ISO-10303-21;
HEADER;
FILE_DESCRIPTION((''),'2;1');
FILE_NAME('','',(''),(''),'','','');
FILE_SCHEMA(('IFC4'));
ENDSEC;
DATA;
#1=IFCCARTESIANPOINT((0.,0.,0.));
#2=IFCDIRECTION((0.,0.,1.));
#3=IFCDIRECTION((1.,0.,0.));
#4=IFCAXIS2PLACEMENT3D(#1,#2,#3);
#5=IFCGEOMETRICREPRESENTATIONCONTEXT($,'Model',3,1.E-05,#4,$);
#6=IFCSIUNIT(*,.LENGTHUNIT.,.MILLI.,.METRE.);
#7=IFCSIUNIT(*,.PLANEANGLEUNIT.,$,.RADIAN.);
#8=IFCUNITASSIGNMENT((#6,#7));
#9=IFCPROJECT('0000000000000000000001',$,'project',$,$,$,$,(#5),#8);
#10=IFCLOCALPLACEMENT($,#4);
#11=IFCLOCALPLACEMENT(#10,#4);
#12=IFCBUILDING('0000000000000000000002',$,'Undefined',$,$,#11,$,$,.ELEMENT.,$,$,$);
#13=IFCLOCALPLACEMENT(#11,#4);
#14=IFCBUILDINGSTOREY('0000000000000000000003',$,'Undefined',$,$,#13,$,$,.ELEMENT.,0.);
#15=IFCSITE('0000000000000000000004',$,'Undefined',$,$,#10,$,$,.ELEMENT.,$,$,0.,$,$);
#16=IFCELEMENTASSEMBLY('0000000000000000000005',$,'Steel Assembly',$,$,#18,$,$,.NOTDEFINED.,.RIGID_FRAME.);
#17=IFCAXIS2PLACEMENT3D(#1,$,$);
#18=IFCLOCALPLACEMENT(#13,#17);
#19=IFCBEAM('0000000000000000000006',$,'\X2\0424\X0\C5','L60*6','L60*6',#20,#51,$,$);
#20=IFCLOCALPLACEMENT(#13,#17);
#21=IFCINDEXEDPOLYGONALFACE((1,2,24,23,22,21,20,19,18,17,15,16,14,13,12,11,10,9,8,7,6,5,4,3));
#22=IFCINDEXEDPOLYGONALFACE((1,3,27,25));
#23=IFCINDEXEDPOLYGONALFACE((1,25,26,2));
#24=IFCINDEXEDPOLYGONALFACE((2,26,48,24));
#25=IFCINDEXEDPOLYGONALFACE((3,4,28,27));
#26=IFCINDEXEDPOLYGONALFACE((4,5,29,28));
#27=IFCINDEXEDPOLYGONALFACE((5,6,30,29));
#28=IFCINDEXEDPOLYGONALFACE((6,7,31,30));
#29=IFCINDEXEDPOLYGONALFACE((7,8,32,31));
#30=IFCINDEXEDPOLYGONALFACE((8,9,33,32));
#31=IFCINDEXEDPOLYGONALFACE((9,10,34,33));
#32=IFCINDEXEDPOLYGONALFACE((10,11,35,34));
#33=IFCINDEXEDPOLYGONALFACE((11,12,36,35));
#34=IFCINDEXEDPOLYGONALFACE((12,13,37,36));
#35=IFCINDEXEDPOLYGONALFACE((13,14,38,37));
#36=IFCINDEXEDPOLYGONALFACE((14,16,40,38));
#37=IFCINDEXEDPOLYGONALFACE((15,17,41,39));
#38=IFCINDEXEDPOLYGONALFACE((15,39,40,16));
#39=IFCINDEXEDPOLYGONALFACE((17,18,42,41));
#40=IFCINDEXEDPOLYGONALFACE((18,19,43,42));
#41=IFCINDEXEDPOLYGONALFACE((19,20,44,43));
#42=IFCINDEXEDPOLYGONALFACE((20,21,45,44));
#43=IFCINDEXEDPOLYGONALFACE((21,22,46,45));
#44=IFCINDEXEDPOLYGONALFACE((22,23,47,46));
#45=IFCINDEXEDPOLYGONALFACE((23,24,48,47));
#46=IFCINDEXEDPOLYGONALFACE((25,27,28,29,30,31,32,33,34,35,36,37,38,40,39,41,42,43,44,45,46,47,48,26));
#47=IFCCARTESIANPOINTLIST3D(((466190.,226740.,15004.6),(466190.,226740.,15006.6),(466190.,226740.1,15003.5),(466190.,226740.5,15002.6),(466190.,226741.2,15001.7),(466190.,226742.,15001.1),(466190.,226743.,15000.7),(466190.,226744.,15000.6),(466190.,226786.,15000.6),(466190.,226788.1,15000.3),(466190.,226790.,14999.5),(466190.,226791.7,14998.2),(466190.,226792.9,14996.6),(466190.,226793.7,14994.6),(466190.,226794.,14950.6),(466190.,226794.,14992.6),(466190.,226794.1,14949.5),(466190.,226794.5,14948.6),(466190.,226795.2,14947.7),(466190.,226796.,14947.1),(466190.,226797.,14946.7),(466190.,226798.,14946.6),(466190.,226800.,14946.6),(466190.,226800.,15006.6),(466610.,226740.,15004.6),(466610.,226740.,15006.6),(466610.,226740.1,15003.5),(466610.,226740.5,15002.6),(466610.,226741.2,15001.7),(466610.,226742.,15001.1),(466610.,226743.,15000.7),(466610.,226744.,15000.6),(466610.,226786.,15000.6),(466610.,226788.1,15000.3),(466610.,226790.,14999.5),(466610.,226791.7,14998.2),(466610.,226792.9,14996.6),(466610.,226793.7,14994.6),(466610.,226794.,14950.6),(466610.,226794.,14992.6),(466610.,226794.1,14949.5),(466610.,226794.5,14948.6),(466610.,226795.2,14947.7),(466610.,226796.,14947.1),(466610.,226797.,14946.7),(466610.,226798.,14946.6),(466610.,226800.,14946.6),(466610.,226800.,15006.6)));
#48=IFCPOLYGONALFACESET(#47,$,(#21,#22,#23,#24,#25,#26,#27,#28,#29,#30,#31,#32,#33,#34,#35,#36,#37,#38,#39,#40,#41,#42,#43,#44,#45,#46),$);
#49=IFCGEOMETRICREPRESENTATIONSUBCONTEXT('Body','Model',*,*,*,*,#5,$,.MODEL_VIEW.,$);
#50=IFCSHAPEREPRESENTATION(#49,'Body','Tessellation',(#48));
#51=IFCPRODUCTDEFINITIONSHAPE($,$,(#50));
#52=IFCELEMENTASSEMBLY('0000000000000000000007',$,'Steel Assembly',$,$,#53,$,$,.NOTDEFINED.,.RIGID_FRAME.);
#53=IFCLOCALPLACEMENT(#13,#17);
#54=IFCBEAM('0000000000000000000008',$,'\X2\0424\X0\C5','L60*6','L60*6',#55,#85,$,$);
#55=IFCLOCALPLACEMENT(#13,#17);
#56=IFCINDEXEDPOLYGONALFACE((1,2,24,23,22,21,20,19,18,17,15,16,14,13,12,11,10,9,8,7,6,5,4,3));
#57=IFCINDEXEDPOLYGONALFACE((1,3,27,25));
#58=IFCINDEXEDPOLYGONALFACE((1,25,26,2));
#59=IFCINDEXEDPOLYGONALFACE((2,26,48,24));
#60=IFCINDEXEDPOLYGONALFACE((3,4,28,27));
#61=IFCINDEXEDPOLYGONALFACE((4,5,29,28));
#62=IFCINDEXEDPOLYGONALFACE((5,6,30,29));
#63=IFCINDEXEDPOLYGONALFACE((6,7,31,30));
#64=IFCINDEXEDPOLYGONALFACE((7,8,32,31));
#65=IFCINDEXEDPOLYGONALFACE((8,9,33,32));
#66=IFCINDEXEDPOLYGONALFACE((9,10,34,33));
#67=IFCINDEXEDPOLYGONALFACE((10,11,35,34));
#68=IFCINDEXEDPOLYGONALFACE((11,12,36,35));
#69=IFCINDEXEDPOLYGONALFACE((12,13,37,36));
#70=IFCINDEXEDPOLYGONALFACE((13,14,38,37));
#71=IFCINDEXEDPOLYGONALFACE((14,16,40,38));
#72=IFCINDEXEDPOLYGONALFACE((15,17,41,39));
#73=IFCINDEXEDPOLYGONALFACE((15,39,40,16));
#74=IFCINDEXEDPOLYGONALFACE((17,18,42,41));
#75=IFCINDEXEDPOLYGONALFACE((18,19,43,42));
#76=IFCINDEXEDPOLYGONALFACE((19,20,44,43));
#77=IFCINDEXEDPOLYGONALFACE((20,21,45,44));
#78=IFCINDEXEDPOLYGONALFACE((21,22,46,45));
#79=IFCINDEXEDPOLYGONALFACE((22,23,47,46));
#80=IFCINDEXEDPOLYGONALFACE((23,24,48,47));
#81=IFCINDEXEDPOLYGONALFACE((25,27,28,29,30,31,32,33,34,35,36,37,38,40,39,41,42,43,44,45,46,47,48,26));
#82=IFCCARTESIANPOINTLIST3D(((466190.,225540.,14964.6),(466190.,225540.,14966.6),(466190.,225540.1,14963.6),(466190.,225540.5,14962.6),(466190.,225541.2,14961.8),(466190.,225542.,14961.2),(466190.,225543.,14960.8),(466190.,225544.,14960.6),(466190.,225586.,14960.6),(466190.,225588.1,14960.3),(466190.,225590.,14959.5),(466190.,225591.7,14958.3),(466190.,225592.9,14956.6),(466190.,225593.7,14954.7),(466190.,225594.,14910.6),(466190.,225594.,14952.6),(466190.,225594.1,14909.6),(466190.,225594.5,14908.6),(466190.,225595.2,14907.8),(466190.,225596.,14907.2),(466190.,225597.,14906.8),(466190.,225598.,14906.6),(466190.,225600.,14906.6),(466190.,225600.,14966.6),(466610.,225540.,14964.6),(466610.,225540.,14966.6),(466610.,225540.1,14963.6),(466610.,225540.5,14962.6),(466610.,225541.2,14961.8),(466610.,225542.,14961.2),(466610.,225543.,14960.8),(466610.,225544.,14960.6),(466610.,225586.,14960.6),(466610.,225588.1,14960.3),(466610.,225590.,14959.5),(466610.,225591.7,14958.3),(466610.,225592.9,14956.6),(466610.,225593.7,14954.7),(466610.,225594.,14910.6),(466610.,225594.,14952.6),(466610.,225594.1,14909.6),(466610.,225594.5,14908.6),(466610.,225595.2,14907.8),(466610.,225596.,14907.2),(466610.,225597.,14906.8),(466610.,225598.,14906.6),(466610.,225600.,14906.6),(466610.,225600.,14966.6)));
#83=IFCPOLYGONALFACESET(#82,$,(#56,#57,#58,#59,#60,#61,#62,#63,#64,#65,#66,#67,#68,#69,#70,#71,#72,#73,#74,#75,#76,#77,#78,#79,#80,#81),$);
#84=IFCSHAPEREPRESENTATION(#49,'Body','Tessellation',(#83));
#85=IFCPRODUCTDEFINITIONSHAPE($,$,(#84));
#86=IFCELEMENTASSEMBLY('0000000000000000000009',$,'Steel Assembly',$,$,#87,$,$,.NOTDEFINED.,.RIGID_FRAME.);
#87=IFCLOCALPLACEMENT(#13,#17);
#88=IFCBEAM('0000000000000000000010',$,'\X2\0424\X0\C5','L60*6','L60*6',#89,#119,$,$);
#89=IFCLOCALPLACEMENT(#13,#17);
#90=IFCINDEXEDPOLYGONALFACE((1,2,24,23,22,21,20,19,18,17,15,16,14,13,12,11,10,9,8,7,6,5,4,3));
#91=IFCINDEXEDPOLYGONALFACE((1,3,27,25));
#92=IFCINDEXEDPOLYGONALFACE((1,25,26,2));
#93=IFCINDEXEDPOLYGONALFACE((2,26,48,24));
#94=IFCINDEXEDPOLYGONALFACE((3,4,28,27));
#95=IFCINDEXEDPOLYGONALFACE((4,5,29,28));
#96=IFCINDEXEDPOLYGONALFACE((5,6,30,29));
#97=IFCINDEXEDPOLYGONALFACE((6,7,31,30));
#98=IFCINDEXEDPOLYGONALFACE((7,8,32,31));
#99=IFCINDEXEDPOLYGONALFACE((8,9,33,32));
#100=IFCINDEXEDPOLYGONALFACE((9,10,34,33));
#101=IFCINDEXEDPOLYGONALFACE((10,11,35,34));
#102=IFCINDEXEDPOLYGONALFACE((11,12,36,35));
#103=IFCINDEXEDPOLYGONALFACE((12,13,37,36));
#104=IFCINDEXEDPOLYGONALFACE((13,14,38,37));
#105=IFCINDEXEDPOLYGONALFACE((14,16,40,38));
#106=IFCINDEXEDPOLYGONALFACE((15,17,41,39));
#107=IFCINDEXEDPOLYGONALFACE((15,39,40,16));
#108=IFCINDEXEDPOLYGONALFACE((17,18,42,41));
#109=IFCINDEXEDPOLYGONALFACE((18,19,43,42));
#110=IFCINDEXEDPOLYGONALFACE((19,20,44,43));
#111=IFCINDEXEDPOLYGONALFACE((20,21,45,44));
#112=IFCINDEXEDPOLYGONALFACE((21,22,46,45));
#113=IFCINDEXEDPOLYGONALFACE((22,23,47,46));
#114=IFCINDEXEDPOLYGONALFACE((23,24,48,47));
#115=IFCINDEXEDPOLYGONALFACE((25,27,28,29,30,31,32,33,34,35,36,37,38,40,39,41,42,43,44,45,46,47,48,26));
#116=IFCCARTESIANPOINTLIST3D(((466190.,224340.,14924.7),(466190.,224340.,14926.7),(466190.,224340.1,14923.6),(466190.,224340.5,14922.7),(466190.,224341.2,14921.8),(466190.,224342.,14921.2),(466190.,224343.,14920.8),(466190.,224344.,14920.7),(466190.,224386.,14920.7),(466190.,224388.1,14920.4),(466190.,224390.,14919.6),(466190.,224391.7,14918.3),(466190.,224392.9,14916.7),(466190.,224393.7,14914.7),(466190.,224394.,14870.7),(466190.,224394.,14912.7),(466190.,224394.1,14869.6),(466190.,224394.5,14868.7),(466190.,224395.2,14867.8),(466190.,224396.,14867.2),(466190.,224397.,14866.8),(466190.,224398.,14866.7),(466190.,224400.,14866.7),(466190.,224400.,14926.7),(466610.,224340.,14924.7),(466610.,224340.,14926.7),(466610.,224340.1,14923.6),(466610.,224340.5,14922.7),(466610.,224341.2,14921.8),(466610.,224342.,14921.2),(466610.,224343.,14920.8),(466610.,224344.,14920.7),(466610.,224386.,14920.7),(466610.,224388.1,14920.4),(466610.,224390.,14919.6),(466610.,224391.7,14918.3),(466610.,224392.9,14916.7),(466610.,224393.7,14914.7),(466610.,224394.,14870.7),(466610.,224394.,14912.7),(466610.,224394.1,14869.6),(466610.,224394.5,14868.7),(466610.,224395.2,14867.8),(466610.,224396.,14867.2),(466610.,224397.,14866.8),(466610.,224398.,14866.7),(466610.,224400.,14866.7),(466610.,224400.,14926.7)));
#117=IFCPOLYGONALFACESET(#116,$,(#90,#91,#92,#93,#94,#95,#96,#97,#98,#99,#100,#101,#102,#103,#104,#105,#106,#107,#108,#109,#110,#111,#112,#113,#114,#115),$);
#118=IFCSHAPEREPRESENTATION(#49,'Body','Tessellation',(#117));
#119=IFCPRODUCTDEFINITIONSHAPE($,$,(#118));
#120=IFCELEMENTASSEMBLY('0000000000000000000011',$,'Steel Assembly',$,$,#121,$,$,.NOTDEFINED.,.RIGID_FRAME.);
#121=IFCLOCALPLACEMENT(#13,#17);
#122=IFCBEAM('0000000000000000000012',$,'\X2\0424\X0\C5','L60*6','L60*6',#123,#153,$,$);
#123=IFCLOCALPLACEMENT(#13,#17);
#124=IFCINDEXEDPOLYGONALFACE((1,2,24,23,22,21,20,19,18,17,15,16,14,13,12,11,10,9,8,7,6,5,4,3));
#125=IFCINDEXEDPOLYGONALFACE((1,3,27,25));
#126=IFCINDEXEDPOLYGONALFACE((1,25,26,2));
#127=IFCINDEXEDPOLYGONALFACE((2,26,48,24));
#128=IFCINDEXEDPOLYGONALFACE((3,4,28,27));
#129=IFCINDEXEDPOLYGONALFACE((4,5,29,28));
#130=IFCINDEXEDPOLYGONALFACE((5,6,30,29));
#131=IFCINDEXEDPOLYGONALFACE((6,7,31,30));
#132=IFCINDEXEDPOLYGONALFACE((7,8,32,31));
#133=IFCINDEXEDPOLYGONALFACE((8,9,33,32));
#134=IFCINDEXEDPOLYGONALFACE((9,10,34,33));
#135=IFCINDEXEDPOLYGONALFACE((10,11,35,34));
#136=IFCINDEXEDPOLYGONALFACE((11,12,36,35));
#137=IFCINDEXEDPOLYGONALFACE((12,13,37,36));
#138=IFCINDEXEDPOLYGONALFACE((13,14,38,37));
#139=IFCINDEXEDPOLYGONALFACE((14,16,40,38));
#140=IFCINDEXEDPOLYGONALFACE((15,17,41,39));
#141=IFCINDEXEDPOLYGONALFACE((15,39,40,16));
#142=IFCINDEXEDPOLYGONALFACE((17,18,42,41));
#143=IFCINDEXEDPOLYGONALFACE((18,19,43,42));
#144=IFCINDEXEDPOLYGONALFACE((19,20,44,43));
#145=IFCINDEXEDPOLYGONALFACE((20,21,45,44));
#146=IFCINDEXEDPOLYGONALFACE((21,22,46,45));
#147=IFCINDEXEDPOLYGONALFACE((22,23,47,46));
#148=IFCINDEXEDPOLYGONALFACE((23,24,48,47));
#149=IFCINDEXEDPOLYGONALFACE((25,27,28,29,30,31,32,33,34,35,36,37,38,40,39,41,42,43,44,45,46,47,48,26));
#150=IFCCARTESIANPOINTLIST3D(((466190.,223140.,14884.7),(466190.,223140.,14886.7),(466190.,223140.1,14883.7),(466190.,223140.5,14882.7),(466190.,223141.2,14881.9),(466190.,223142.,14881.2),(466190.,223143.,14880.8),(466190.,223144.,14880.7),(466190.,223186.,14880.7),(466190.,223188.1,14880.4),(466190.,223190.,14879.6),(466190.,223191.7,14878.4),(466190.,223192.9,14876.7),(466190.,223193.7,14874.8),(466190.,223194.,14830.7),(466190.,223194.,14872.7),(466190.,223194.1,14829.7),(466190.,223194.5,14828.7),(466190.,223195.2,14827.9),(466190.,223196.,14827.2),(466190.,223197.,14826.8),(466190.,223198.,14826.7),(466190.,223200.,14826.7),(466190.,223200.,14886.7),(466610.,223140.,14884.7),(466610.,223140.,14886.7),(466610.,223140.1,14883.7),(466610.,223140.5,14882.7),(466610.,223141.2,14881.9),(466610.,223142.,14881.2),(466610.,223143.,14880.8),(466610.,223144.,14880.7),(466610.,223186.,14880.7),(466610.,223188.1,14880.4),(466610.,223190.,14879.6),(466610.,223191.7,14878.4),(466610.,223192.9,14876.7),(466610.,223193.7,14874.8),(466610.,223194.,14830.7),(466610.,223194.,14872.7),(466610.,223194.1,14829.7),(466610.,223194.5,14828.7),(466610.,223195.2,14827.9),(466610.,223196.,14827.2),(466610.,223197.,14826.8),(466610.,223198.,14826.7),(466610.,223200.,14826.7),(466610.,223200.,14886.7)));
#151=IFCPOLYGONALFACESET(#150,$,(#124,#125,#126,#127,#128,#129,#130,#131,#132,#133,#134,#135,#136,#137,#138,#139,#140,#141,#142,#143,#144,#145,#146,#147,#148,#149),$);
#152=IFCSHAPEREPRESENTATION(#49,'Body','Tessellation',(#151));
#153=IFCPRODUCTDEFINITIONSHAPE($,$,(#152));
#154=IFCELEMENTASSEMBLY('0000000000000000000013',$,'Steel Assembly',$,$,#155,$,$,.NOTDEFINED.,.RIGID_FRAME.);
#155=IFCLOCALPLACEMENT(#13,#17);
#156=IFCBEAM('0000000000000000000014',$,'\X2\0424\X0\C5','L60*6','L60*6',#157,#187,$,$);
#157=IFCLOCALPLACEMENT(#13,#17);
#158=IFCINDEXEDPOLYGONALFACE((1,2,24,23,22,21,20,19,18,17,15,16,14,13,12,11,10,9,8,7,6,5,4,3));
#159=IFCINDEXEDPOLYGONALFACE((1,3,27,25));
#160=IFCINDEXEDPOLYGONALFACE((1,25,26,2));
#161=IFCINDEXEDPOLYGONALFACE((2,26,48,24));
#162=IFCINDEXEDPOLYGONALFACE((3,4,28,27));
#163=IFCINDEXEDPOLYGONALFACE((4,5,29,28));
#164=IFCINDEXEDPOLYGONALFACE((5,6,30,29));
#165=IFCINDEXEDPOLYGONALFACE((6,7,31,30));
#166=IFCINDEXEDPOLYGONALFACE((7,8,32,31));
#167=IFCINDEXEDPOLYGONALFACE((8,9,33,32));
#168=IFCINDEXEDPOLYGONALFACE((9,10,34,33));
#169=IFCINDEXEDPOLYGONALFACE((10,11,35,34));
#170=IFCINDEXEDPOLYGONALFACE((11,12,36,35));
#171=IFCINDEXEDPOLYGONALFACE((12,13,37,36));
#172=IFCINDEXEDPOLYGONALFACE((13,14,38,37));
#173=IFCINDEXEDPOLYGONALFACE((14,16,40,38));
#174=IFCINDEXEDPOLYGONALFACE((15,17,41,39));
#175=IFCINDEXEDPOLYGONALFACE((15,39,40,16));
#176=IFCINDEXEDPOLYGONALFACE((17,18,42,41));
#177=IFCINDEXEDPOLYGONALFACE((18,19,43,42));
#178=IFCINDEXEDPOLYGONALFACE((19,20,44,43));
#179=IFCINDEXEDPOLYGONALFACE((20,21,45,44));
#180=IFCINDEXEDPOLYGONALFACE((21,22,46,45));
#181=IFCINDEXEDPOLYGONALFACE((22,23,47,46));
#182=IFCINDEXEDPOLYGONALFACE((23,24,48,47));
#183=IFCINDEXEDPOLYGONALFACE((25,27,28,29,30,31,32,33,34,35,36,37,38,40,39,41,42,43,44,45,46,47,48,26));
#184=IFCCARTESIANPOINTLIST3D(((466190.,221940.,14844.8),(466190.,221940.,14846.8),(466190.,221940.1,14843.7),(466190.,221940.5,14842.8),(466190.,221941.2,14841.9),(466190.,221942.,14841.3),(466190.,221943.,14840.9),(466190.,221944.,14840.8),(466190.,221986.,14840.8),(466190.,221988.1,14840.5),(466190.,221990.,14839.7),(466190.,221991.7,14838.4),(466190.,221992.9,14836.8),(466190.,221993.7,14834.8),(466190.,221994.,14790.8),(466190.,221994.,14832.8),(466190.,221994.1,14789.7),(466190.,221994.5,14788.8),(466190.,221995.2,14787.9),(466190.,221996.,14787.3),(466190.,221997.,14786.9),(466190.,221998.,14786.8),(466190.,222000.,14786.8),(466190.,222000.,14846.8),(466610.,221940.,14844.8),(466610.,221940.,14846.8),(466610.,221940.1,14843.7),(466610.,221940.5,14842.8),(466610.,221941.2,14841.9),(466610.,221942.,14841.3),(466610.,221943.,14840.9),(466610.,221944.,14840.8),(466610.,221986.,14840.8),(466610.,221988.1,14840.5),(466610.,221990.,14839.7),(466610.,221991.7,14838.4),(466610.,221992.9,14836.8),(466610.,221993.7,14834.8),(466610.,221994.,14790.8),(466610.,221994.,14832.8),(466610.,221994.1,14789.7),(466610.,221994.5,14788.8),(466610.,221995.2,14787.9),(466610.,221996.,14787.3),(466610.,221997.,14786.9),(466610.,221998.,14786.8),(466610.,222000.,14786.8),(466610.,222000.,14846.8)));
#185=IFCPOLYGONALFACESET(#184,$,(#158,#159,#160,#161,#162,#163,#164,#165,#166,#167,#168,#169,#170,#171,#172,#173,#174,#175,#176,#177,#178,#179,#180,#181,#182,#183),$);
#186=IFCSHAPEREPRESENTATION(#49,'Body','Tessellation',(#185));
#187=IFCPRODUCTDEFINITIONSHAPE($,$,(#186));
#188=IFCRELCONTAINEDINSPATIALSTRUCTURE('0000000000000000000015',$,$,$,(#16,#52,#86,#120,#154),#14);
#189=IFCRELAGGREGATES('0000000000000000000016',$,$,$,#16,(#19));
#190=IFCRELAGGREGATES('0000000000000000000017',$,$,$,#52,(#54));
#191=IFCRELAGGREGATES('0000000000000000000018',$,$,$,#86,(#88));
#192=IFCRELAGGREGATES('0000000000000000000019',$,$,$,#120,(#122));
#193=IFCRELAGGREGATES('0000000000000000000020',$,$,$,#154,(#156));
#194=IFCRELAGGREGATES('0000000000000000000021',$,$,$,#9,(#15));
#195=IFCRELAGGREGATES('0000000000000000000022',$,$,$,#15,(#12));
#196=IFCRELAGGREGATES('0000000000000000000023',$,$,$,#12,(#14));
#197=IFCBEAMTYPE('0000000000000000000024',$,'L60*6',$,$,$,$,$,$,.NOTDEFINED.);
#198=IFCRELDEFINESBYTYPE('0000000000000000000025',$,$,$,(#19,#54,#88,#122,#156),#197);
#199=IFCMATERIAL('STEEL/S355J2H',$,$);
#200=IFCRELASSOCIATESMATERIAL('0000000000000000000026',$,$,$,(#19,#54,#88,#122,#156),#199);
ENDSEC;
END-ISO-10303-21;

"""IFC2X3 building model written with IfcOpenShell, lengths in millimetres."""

from ifc_helpers import new_model, si_unit, frame, origin_with_axes, origin_2d_with_axis, place, context, subcontext, project, spatial, l_section, extrude, material, type_object, element, aggregate, save


model = new_model("IFC2X3")

# Units and contexts
model_context = context("Model", 3, precision=1e-05, world=origin_with_axes())
body_context = subcontext(model_context, "Body", "Model", "MODEL_VIEW")
ifc_project = project(units=[si_unit("LENGTHUNIT", "METRE", prefix="MILLI"), si_unit("PLANEANGLEUNIT", "RADIAN")], contexts=[model_context])

# Site, building, storey
site_placement = place(None, origin_with_axes())
site = spatial("IfcSite", under=ifc_project, at=site_placement, Name="Undefined", CompositionType="ELEMENT", RefElevation=0.0)
building_placement = place(site_placement, origin_with_axes())
building = spatial("IfcBuilding", under=site, at=building_placement, Name="Undefined", CompositionType="ELEMENT")
storey_placement = place(building_placement, origin_with_axes())
storey = spatial("IfcBuildingStorey", under=building, at=storey_placement, Name="Undefined", CompositionType="ELEMENT", Elevation=0.0)

# Element assemblies, beams
assembly_1_placement = place(storey_placement, origin_with_axes())
assembly_1 = element("IfcElementAssembly", 1, at=assembly_1_placement, inside=storey, Name="Steel Assembly", AssemblyPlace="NOTDEFINED", PredefinedType="RIGID_FRAME")
ifc_material_1 = material(Name="STEEL/S355J2H")
beam_type = type_object("IfcBeamType", Name="L60*6", PredefinedType="NOTDEFINED")
beam_1_placement = place(assembly_1_placement, frame((466190.0, 226770.0, 14976.6), z_axis=(0.0, -1.0, 0.0), x_axis=(1.0, 0.0, 0.0)))
beam_1 = element("IfcBeam", 2, at=beam_1_placement, type_object=beam_type, material=ifc_material_1, Name="ФC5", Description="L60*6", ObjectType="L60*6", context=body_context, shape_type="SweptSolid", body=[
    extrude(l_section(Depth=60.0, Width=60.0, Thickness=6.0, FilletRadius=8.0, EdgeRadius=4.0, at=origin_2d_with_axis()), frame((420.0, 0.0, 0.0), z_axis=(-1.0, 0.0, 0.0), x_axis=(0.0, -1.0, 0.0)), (0.0, 0.0, 1.0), 420.0),
])
aggregate(assembly_1, [beam_1])
assembly_2_placement = place(storey_placement, origin_with_axes())
assembly_2 = element("IfcElementAssembly", 3, at=assembly_2_placement, inside=storey, Name="Steel Assembly", AssemblyPlace="NOTDEFINED", PredefinedType="RIGID_FRAME")
beam_2_placement = place(assembly_2_placement, frame((466190.0, 225570.0, 14936.6), z_axis=(0.0, -1.0, 0.0), x_axis=(1.0, 0.0, 0.0)))
beam_2 = element("IfcBeam", 4, at=beam_2_placement, type_object=beam_type, material=ifc_material_1, Name="ФC5", Description="L60*6", ObjectType="L60*6", context=body_context, shape_type="SweptSolid", body=[
    extrude(l_section(Depth=60.0, Width=60.0, Thickness=6.0, FilletRadius=8.0, EdgeRadius=4.0, at=origin_2d_with_axis()), frame((420.0, 0.0, 0.0), z_axis=(-1.0, 0.0, 0.0), x_axis=(0.0, -1.0, 0.0)), (0.0, 0.0, 1.0), 420.0),
])
aggregate(assembly_2, [beam_2])
assembly_3_placement = place(storey_placement, origin_with_axes())
assembly_3 = element("IfcElementAssembly", 5, at=assembly_3_placement, inside=storey, Name="Steel Assembly", AssemblyPlace="NOTDEFINED", PredefinedType="RIGID_FRAME")
beam_3_placement = place(assembly_3_placement, frame((466190.0, 224370.0, 14896.7), z_axis=(0.0, -1.0, 0.0), x_axis=(1.0, 0.0, 0.0)))
beam_3 = element("IfcBeam", 6, at=beam_3_placement, type_object=beam_type, material=ifc_material_1, Name="ФC5", Description="L60*6", ObjectType="L60*6", context=body_context, shape_type="SweptSolid", body=[
    extrude(l_section(Depth=60.0, Width=60.0, Thickness=6.0, FilletRadius=8.0, EdgeRadius=4.0, at=origin_2d_with_axis()), frame((420.0, 0.0, 0.0), z_axis=(-1.0, 0.0, 0.0), x_axis=(0.0, -1.0, 0.0)), (0.0, 0.0, 1.0), 420.0),
])
aggregate(assembly_3, [beam_3])
assembly_4_placement = place(storey_placement, origin_with_axes())
assembly_4 = element("IfcElementAssembly", 7, at=assembly_4_placement, inside=storey, Name="Steel Assembly", AssemblyPlace="NOTDEFINED", PredefinedType="RIGID_FRAME")
beam_4_placement = place(assembly_4_placement, frame((466190.0, 223170.0, 14856.7), z_axis=(0.0, -1.0, 0.0), x_axis=(1.0, 0.0, 0.0)))
beam_4 = element("IfcBeam", 8, at=beam_4_placement, type_object=beam_type, material=ifc_material_1, Name="ФC5", Description="L60*6", ObjectType="L60*6", context=body_context, shape_type="SweptSolid", body=[
    extrude(l_section(Depth=60.0, Width=60.0, Thickness=6.0, FilletRadius=8.0, EdgeRadius=4.0, at=origin_2d_with_axis()), frame((420.0, 0.0, 0.0), z_axis=(-1.0, 0.0, 0.0), x_axis=(0.0, -1.0, 0.0)), (0.0, 0.0, 1.0), 420.0),
])
aggregate(assembly_4, [beam_4])
assembly_5_placement = place(storey_placement, origin_with_axes())
assembly_5 = element("IfcElementAssembly", 9, at=assembly_5_placement, inside=storey, Name="Steel Assembly", AssemblyPlace="NOTDEFINED", PredefinedType="RIGID_FRAME")
beam_5_placement = place(assembly_5_placement, frame((466190.0, 221970.0, 14816.8), z_axis=(0.0, -1.0, 0.0), x_axis=(1.0, 0.0, 0.0)))
beam_5 = element("IfcBeam", 10, at=beam_5_placement, type_object=beam_type, material=ifc_material_1, Name="ФC5", Description="L60*6", ObjectType="L60*6", context=body_context, shape_type="SweptSolid", body=[
    extrude(l_section(Depth=60.0, Width=60.0, Thickness=6.0, FilletRadius=8.0, EdgeRadius=4.0, at=origin_2d_with_axis()), frame((420.0, 0.0, 0.0), z_axis=(-1.0, 0.0, 0.0), x_axis=(0.0, -1.0, 0.0)), (0.0, 0.0, 1.0), 420.0),
])
aggregate(assembly_5, [beam_5])

save(model, "model.ifc")
